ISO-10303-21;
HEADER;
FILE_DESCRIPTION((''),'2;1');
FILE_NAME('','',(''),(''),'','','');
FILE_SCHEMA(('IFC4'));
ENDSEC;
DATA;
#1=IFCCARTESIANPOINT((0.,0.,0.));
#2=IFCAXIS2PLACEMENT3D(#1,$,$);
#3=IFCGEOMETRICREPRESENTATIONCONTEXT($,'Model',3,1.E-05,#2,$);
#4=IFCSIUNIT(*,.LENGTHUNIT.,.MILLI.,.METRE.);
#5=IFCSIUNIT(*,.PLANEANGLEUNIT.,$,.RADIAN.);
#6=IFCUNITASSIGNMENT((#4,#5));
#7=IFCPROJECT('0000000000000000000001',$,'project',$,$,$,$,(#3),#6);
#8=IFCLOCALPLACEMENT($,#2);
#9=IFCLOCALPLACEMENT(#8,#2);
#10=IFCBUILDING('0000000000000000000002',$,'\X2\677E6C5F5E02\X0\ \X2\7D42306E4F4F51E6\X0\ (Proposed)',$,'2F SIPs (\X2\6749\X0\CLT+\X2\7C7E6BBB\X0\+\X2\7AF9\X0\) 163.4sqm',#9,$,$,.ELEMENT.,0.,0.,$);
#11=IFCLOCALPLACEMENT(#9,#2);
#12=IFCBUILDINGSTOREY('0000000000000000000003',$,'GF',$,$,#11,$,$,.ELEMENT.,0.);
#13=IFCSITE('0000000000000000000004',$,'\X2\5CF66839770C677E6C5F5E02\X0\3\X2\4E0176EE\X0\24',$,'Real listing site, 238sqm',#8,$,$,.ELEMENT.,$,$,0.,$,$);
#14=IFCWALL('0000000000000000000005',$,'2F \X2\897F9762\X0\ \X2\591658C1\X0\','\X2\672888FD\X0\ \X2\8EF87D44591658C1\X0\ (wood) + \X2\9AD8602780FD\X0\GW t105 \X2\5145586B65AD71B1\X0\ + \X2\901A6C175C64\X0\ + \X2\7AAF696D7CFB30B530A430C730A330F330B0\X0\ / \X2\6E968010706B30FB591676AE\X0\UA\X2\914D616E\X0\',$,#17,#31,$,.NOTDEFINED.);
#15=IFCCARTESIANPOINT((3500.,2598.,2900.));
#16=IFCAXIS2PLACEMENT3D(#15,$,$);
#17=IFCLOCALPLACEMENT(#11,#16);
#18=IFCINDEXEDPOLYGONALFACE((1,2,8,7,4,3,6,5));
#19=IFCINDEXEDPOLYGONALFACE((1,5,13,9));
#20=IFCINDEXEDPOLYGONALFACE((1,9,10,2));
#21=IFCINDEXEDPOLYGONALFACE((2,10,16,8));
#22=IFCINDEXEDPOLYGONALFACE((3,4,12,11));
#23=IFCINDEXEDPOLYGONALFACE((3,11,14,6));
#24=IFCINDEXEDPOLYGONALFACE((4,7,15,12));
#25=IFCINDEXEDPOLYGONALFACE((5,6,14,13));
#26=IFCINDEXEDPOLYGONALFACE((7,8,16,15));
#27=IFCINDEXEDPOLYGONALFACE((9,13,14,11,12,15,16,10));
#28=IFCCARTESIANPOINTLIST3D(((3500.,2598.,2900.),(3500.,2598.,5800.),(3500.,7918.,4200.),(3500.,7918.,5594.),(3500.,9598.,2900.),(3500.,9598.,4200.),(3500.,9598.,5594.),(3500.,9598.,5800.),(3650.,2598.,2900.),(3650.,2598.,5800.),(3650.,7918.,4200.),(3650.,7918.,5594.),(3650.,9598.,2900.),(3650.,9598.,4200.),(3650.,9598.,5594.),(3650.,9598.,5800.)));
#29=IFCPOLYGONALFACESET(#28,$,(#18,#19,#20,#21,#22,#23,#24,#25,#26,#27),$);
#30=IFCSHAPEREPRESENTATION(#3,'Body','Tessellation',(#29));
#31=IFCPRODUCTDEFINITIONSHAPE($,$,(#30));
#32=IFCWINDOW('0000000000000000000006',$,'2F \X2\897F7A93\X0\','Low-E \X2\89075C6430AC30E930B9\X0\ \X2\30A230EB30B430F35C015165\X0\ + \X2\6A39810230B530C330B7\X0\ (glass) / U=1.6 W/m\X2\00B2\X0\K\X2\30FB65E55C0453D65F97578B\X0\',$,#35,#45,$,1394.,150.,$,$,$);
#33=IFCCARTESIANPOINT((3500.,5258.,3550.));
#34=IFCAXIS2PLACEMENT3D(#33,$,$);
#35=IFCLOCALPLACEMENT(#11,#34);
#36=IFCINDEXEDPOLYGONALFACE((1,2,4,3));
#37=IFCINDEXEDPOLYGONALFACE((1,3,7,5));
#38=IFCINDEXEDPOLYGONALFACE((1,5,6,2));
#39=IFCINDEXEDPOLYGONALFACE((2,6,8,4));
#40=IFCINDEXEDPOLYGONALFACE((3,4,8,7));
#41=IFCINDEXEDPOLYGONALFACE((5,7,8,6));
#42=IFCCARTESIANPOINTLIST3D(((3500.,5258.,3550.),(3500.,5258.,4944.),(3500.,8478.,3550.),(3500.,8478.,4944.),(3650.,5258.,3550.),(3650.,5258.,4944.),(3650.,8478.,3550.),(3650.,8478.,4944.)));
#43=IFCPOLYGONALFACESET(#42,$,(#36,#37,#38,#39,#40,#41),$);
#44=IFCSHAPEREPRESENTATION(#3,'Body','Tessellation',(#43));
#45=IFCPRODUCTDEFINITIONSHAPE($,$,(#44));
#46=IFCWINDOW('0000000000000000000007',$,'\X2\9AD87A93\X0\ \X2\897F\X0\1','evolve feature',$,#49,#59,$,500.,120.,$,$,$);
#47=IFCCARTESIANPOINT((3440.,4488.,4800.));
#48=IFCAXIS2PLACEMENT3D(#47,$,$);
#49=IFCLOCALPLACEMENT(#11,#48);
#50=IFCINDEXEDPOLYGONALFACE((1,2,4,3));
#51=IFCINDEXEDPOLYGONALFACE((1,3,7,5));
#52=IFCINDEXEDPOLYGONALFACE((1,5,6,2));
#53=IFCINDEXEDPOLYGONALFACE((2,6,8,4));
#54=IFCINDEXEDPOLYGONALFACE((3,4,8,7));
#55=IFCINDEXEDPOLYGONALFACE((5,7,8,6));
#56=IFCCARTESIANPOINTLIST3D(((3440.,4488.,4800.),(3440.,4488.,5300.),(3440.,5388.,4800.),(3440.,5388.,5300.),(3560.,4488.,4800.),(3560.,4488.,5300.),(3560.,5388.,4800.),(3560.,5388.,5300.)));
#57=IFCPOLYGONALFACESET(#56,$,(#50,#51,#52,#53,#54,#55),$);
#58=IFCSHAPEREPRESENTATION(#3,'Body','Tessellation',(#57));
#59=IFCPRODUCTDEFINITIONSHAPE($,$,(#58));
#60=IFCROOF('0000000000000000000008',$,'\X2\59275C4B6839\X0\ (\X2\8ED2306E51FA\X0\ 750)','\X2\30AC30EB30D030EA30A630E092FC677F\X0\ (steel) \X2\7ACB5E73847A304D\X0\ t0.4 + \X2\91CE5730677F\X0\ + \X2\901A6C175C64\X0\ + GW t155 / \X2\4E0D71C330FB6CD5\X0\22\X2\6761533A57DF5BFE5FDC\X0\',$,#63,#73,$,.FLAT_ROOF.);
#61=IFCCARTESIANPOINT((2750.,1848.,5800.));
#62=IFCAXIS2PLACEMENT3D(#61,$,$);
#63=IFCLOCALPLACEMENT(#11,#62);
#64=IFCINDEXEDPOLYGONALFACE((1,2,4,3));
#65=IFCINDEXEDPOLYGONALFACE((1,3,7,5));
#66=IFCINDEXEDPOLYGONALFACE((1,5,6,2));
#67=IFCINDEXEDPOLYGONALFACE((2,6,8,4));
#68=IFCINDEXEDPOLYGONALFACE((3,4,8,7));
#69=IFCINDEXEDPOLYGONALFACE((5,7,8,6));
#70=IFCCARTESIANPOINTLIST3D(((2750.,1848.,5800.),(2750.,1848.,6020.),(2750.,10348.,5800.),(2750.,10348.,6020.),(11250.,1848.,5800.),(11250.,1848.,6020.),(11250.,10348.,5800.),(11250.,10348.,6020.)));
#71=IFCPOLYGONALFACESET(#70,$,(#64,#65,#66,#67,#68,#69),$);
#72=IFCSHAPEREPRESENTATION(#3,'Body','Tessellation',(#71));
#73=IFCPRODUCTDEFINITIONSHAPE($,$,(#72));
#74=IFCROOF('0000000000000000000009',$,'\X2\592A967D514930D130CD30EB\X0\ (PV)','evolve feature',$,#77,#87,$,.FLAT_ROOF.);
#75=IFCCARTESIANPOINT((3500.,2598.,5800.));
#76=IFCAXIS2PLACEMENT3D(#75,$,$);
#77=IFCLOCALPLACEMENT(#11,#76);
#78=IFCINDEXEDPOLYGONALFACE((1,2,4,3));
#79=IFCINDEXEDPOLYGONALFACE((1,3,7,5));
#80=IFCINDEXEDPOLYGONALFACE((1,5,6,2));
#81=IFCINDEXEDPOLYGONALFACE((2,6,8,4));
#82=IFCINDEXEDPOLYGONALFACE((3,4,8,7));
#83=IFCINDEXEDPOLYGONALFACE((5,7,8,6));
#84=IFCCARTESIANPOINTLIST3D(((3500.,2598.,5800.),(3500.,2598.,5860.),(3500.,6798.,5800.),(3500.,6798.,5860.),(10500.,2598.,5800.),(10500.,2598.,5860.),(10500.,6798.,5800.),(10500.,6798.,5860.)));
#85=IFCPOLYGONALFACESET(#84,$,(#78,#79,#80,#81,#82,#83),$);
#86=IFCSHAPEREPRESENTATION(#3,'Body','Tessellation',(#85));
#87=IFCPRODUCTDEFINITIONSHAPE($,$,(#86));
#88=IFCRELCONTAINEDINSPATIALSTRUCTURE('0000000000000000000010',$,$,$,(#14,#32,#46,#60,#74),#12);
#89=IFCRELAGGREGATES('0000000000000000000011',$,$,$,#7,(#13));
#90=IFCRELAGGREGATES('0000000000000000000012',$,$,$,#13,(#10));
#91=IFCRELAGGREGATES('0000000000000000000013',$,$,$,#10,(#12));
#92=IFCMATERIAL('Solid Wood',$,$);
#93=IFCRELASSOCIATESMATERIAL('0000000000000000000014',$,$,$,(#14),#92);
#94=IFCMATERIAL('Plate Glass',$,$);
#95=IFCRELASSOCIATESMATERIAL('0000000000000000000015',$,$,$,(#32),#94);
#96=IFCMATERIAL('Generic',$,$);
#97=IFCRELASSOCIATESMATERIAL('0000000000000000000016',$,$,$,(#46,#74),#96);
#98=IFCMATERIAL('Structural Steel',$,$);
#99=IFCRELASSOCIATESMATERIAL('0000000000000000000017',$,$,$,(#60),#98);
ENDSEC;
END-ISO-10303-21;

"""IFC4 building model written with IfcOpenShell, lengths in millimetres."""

from ifc_helpers import new_model, si_unit, frame, frame_2d, origin, place, context, project, spatial, rectangle, extrude, material, element, fill, save


model = new_model("IFC4")

# Units and contexts
model_context = context("Model", 3, precision=1e-05, world=origin())
ifc_project = project(units=[si_unit("LENGTHUNIT", "METRE", prefix="MILLI"), si_unit("PLANEANGLEUNIT", "RADIAN")], contexts=[model_context])

# Site, building, storey
site_placement = place(None, origin())
site = spatial("IfcSite", under=ifc_project, at=site_placement, Name="島根県松江市3丁目24", ObjectType="Real listing site, 238sqm", CompositionType="ELEMENT", RefElevation=0.0)
building_placement = place(site_placement, origin())
building = spatial("IfcBuilding", under=site, at=building_placement, Name="松江市 終の住処 (Proposed)", ObjectType="2F SIPs (杉CLT+籾殻+竹) 163.4sqm", CompositionType="ELEMENT", ElevationOfRefHeight=0.0, ElevationOfTerrain=0.0)
storey_placement = place(building_placement, origin())
storey = spatial("IfcBuildingStorey", under=building, at=storey_placement, Name="GF", CompositionType="ELEMENT", Elevation=0.0)

# Shared definitions
ifc_material_1 = material(Name="Solid Wood")
ifc_material_2 = material(Name="Generic")

# Shared definitions
ifc_material_3 = material(Name="Plate Glass")

# Wall, openings, windows
wall_1_placement = place(storey_placement, frame((3500.0, 2598.0, 2900.0)))
wall_1 = element("IfcWall", 1, at=wall_1_placement, inside=storey, material=ifc_material_1, Name="2F 西面 外壁", Description="木製 軸組外壁 (wood) + 高性能GW t105 充填断熱 + 通気層 + 窯業系サイディング / 準耐火・外皮UA配慮", PredefinedType="NOTDEFINED", context=model_context, shape_type="SweptSolid", body=[
    extrude(rectangle(XDim=150.0, YDim=7000.0, at=frame_2d((75.0, 3500.0))), frame((3500.0, 2598.0, 2900.0)), (0.0, 0.0, 1.0), 2900.0),
])
opening_1_placement = place(storey_placement, frame((3500.0, 5258.0, 3550.0)))
opening_1 = element("IfcOpeningElement", 2, at=opening_1_placement, cuts=wall_1, PredefinedType="NOTDEFINED", context=model_context, shape_type="SweptSolid", body=[
    extrude(rectangle(XDim=150.0, YDim=3220.0, at=frame_2d((75.0, 1610.0))), frame((3500.0, 5258.0, 3550.0)), (0.0, 0.0, 1.0), 1394.0),
])
opening_2_placement = place(storey_placement, frame((3440.0, 4488.0, 4800.0)))
opening_2 = element("IfcOpeningElement", 3, at=opening_2_placement, cuts=wall_1, PredefinedType="NOTDEFINED", context=model_context, shape_type="SweptSolid", body=[
    extrude(rectangle(XDim=120.0, YDim=900.0, at=frame_2d((60.0, 450.0))), frame((3440.0, 4488.0, 4800.0)), (0.0, 0.0, 1.0), 500.0),
])
window_1_placement = place(storey_placement, frame((3500.0, 5258.0, 3550.0)))
window_1 = element("IfcWindow", 4, at=window_1_placement, inside=storey, material=ifc_material_3, Name="2F 西窓", Description="Low-E 複層ガラス アルゴン封入 + 樹脂サッシ (glass) / U=1.6 W/m²K・日射取得型", OverallHeight=1394.0, OverallWidth=150.0, context=model_context, shape_type="SweptSolid", body=[
    extrude(rectangle(XDim=150.0, YDim=3220.0, at=frame_2d((75.0, 1610.0))), frame((3500.0, 5258.0, 3550.0)), (0.0, 0.0, 1.0), 1394.0),
])
fill(opening_1, window_1)
window_2_placement = place(storey_placement, frame((3440.0, 4488.0, 4800.0)))
window_2 = element("IfcWindow", 5, at=window_2_placement, inside=storey, material=ifc_material_2, Name="高窓 西1", Description="evolve feature", OverallHeight=500.0, OverallWidth=120.0, context=model_context, shape_type="SweptSolid", body=[
    extrude(rectangle(XDim=120.0, YDim=900.0, at=frame_2d((60.0, 450.0))), frame((3440.0, 4488.0, 4800.0)), (0.0, 0.0, 1.0), 500.0),
])
fill(opening_2, window_2)

# Roofs
ifc_material_4 = material(Name="Structural Steel")
roof_1_placement = place(storey_placement, frame((2750.0, 1848.0, 5800.0)))
element("IfcRoof", 6, at=roof_1_placement, inside=storey, material=ifc_material_4, Name="大屋根 (軒の出 750)", Description="ガルバリウム鋼板 (steel) 立平葺き t0.4 + 野地板 + 通気層 + GW t155 / 不燃・法22条区域対応", PredefinedType="FLAT_ROOF", context=model_context, shape_type="SweptSolid", body=[
    extrude(rectangle(XDim=8500.0, YDim=8500.0, at=frame_2d((4250.0, 4250.0))), frame((2750.0, 1848.0, 5800.0)), (0.0, 0.0, 1.0), 220.0),
])
roof_2_placement = place(storey_placement, frame((3500.0, 2598.0, 5800.0)))
element("IfcRoof", 7, at=roof_2_placement, inside=storey, material=ifc_material_2, Name="太陽光パネル (PV)", Description="evolve feature", PredefinedType="FLAT_ROOF", context=model_context, shape_type="SweptSolid", body=[
    extrude(rectangle(XDim=7000.0, YDim=4200.0, at=frame_2d((3500.0, 2100.0))), frame((3500.0, 2598.0, 5800.0)), (0.0, 0.0, 1.0), 60.0),
])

save(model, "model.ifc")
